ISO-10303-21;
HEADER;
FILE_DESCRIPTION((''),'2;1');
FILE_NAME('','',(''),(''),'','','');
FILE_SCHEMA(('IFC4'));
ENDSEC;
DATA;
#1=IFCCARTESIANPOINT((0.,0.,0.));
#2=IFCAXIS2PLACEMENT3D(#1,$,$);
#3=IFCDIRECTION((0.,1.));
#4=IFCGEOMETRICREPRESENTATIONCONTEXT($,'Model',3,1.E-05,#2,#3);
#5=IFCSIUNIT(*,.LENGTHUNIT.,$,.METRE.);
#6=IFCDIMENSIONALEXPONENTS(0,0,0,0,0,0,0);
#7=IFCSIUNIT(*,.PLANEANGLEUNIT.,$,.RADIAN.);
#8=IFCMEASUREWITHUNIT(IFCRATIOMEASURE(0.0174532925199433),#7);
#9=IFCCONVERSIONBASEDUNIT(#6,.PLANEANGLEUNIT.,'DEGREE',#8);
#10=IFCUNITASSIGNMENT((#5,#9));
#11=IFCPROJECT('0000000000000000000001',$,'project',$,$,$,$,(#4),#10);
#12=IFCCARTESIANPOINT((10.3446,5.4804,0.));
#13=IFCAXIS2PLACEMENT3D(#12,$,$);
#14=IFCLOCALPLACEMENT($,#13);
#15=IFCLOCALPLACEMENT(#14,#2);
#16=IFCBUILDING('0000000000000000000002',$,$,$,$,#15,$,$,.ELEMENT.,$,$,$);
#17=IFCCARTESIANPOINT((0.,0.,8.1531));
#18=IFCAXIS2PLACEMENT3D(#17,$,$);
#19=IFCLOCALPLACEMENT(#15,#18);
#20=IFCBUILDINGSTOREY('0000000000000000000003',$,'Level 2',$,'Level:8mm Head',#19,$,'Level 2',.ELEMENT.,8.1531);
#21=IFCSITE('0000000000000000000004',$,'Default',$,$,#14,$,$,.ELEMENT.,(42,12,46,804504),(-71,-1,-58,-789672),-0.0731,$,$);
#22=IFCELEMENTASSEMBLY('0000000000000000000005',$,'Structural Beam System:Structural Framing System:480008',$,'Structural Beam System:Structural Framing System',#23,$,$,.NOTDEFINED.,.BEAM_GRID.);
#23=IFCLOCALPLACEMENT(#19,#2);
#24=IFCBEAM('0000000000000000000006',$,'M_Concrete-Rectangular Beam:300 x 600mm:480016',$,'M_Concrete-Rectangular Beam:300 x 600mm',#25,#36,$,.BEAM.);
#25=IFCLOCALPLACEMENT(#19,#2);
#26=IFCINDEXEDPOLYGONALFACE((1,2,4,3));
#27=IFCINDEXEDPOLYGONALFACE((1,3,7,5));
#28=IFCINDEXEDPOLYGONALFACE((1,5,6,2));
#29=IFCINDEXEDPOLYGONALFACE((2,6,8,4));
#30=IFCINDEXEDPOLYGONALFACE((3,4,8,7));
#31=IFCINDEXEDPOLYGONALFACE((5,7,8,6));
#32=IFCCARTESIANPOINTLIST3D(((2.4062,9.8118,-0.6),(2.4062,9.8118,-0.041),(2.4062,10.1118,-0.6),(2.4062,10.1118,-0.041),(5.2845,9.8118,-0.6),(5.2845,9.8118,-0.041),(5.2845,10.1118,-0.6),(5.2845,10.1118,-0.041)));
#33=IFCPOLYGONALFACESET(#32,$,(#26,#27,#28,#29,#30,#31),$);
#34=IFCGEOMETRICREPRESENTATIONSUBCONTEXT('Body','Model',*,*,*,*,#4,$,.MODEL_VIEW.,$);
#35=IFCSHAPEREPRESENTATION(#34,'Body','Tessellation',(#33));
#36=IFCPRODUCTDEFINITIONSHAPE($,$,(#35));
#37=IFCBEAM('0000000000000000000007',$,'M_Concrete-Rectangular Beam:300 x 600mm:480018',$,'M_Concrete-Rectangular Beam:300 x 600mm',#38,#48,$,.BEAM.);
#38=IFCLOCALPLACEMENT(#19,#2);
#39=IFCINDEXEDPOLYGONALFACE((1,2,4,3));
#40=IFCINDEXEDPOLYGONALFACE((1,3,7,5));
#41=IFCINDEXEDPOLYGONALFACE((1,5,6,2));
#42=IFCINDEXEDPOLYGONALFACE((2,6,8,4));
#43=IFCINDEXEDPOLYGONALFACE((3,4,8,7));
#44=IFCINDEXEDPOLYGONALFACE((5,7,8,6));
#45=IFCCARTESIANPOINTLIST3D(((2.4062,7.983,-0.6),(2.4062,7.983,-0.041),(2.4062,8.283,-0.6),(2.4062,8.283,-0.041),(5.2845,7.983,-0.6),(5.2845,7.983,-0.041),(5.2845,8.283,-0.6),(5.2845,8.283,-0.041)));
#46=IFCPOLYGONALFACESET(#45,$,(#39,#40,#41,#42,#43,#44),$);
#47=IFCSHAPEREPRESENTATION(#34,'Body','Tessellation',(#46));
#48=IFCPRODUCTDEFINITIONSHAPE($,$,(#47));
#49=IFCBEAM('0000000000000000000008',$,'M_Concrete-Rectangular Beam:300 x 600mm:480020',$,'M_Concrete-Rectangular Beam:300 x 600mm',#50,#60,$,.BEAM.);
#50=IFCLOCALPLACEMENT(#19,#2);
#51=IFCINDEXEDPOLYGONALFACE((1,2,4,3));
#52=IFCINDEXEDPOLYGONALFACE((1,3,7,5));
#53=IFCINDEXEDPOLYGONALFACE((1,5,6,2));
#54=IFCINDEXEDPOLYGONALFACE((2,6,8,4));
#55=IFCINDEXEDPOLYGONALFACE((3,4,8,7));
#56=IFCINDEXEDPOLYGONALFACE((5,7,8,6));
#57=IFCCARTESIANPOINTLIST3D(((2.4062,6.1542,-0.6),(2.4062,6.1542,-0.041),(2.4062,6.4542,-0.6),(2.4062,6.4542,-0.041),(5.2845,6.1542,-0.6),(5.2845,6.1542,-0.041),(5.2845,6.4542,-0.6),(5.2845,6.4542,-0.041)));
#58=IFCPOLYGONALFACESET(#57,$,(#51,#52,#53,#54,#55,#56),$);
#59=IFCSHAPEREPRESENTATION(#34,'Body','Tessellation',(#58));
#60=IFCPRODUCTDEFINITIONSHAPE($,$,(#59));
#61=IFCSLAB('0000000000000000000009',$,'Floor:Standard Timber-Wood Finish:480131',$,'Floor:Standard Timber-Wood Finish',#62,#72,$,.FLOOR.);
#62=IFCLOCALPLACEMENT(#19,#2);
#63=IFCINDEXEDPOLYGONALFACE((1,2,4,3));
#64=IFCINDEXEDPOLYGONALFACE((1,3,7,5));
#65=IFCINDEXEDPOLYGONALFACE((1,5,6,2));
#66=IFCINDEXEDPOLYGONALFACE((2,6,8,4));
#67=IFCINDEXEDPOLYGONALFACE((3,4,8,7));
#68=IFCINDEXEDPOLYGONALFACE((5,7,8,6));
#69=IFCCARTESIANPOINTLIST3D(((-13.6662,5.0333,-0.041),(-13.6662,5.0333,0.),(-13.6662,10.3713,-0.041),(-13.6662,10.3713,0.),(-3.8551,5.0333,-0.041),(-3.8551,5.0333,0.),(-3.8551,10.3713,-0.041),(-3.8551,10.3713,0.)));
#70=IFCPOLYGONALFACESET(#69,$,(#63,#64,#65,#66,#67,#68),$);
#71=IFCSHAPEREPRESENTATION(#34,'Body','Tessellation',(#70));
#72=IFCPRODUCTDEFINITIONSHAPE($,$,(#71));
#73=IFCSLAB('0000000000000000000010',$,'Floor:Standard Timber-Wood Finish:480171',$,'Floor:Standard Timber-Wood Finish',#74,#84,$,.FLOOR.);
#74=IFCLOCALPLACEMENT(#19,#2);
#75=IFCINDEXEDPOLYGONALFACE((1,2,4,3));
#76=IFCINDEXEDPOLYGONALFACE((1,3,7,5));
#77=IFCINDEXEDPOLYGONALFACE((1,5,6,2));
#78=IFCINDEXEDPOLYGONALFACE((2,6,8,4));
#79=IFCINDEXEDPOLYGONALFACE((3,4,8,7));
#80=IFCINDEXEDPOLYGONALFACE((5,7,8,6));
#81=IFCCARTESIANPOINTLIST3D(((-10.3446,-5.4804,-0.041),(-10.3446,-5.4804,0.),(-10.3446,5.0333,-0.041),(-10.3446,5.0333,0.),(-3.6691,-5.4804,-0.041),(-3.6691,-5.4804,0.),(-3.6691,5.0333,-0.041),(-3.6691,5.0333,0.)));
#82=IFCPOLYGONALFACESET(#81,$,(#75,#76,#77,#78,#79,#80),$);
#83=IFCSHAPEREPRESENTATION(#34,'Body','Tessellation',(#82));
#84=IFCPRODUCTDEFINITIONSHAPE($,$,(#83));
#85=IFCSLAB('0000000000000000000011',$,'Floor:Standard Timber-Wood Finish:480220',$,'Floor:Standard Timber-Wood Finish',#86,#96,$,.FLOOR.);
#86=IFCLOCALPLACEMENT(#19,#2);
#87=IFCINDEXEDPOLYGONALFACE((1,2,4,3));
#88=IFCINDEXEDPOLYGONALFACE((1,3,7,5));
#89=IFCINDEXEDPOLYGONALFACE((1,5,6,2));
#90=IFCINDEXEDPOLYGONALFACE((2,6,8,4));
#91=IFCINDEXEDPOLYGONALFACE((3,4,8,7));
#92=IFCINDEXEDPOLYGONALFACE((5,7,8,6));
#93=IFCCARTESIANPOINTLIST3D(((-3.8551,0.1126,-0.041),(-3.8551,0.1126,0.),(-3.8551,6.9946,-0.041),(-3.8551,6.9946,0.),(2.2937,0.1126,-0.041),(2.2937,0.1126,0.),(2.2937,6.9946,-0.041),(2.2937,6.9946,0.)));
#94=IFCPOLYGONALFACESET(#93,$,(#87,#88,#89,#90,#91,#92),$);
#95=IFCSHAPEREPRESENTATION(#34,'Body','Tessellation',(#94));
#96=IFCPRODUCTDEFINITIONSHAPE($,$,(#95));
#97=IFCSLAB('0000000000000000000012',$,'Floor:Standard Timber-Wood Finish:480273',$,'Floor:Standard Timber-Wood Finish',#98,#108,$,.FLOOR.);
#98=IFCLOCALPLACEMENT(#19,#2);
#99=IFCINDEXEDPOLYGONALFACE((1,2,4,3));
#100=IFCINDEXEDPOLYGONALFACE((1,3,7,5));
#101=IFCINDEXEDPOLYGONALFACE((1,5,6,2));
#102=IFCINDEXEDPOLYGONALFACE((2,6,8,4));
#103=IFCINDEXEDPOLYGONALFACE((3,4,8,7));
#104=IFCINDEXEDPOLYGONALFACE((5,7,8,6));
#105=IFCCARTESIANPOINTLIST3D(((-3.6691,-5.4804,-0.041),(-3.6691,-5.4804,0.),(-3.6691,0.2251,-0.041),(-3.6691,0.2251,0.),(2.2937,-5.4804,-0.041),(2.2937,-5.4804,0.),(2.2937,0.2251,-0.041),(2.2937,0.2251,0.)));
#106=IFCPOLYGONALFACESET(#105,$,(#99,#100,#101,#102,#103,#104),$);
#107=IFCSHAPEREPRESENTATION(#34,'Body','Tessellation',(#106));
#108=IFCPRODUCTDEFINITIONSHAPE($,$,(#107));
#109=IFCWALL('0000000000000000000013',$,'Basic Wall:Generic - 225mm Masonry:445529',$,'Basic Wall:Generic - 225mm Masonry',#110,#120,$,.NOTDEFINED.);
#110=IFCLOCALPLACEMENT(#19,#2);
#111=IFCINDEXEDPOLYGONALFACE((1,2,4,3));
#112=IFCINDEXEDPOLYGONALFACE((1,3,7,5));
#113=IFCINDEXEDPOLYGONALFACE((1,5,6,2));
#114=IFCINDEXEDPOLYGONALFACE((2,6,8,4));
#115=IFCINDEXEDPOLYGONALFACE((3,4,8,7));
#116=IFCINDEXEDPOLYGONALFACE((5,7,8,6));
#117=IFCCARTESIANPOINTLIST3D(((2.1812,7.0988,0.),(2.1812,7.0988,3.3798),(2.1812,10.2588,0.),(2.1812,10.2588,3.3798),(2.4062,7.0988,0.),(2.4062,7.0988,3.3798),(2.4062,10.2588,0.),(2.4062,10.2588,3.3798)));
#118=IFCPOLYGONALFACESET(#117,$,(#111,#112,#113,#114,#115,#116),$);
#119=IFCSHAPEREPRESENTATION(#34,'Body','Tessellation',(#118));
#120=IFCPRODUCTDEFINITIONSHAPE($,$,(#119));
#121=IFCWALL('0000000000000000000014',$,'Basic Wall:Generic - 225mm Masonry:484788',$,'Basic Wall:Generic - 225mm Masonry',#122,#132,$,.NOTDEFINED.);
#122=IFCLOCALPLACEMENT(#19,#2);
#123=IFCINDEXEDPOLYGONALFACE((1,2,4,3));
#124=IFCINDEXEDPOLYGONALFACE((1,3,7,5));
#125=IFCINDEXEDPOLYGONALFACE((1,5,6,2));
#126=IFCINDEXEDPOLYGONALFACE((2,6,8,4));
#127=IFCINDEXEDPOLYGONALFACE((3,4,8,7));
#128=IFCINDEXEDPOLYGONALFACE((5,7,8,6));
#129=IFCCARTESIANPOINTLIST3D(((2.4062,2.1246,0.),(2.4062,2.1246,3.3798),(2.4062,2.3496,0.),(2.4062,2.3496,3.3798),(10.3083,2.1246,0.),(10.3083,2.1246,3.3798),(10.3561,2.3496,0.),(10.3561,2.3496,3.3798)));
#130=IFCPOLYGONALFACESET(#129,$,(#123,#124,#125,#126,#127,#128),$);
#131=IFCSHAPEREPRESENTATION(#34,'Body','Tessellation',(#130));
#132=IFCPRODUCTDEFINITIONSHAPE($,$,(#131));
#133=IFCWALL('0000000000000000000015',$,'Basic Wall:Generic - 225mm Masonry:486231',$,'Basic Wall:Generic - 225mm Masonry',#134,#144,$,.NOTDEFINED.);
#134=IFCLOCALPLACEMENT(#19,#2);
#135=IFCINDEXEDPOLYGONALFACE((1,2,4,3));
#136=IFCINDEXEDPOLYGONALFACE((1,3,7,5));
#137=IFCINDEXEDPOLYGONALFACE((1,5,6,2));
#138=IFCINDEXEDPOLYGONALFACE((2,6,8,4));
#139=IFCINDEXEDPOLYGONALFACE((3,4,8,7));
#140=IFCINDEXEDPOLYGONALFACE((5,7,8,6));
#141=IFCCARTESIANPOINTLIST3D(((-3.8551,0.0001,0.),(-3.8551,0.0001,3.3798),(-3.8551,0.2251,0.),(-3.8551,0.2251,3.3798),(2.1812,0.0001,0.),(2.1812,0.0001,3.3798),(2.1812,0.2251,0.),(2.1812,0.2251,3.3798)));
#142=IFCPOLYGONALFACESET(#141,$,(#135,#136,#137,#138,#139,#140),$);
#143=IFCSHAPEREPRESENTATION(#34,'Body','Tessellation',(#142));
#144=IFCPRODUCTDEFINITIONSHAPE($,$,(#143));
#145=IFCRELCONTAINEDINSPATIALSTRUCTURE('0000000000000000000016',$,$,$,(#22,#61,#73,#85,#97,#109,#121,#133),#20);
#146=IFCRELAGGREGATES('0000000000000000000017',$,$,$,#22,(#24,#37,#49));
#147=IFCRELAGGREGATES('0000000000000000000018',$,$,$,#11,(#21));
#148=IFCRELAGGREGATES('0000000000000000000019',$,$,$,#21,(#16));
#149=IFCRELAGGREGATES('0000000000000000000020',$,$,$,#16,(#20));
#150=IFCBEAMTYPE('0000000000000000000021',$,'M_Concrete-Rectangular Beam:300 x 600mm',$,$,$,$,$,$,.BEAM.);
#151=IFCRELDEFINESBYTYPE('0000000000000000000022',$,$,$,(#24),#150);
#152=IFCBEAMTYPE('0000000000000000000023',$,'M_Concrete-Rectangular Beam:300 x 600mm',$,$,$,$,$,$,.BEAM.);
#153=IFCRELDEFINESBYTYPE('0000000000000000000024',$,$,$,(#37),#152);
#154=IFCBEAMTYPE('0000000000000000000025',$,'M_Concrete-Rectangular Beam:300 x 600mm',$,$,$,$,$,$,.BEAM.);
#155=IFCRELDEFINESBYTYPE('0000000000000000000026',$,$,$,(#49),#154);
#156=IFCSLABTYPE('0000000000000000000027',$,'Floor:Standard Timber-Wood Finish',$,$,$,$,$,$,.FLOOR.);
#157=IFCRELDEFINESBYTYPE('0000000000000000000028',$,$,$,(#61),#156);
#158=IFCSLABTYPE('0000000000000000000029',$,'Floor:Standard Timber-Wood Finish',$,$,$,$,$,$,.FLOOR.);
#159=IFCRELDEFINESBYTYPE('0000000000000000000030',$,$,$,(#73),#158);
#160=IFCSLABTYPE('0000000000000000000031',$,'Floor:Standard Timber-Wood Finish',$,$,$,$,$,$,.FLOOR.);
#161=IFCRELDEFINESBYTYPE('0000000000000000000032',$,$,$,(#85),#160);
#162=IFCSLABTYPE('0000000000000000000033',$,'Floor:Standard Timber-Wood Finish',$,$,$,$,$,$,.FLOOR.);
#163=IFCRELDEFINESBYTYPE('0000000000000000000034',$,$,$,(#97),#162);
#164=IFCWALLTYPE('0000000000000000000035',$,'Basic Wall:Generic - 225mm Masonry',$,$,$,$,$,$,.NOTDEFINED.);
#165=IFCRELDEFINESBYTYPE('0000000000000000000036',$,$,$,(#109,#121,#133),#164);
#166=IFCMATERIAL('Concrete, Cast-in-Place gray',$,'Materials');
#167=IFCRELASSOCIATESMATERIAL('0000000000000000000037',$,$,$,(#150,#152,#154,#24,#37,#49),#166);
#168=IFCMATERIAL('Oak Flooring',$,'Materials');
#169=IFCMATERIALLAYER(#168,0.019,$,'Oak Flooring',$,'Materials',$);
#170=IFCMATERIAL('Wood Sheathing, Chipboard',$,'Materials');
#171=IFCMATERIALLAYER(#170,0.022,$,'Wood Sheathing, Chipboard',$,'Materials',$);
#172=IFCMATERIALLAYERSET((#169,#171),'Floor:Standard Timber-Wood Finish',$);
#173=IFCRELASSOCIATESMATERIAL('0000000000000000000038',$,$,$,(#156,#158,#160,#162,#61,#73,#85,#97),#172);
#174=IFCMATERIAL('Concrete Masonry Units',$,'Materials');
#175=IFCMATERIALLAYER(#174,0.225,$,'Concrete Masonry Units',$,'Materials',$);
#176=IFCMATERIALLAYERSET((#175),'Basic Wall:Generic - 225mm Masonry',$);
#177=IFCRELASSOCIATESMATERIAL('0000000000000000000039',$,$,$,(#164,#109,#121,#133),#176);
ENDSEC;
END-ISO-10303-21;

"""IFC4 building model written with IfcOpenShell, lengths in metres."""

from ifc_helpers import new_model, entity, si_unit, converted_unit, direction, frame, frame_2d, origin, origin_2d_with_axis, place, context, subcontext, project, spatial, polyline, rectangle, outline, extrude, clip, bounded_halfspace, source, transform, mapped, material, layer, layer_set, layer_usage, material_profile, profile_set, profile_usage, type_object, type_shapes, element, aggregate, save


model = new_model("IFC4")

# Units and contexts
model_context = context("Model", 3, precision=1e-05, world=origin(), true_north=direction((0.0, 1.0)))
body_context = subcontext(model_context, "Body", "Model", "MODEL_VIEW")
ifc_project = project(units=[si_unit("LENGTHUNIT", "METRE"), converted_unit("PLANEANGLEUNIT", "DEGREE", entity("IfcRatioMeasure", 0.0174532925199433), si_unit("PLANEANGLEUNIT", "RADIAN"), dimensions=[0, 0, 0, 0, 0, 0, 0])], contexts=[model_context])

# Site, building, storey
site_placement = place(None, frame((10.3446, 5.4804, 0.0)))
site = spatial("IfcSite", under=ifc_project, at=site_placement, Name="Default", CompositionType="ELEMENT", RefLatitude=(42, 12, 46, 804504), RefLongitude=(-71, -1, -58, -789672), RefElevation=-0.0731)
building_placement = place(site_placement, origin())
building = spatial("IfcBuilding", under=site, at=building_placement, CompositionType="ELEMENT")
storey_placement = place(building_placement, frame((0.0, 0.0, 8.1531)))
storey = spatial("IfcBuildingStorey", under=building, at=storey_placement, Name="Level 2", ObjectType="Level:8mm Head", LongName="Level 2", CompositionType="ELEMENT", Elevation=8.1531)

# Element assembly, beams
ifc_material_1 = material(Name="Concrete, Cast-in-Place gray", Category="Materials")
ifc_material_profile = material_profile(ifc_material_1, rectangle(XDim=0.559, YDim=0.3, at=frame_2d((0.0, 0.0), x_axis=(1.0, 0.0))), Name="300 x 600mm")
ifc_profile_set = profile_set([ifc_material_profile], Name="300 x 600mm")
assembly_1_placement = place(storey_placement, origin())
assembly_1 = element("IfcElementAssembly", 1, at=assembly_1_placement, inside=storey, Name="Structural Beam System:Structural Framing System:480008", ObjectType="Structural Beam System:Structural Framing System", AssemblyPlace="NOTDEFINED", PredefinedType="BEAM_GRID")
ifc_profile_usage_1 = profile_usage(ifc_profile_set, cardinal=8)
beam_type_1 = type_object("IfcBeamType", Name="M_Concrete-Rectangular Beam:300 x 600mm", PredefinedType="BEAM", material=ifc_profile_set)
shared_shape_1 = source(origin(), body_context, "Body", "SweptSolid", [
    extrude(rectangle(XDim=0.559, YDim=0.3, at=frame_2d((0.0, 0.0), x_axis=(1.0, 0.0))), frame((2.4062, 9.9618, 7.8326), z_axis=(1.0, 0.0, 0.0), x_axis=(0.0, 0.0, -1.0)), (0.0, 0.0, 1.0), 2.8784),
])
type_shapes(beam_type_1, [shared_shape_1])
beam_1_placement = place(assembly_1_placement, frame((0.0, 0.0, -8.1531)))
beam_1 = element("IfcBeam", 2, at=beam_1_placement, type_object=beam_type_1, material=ifc_profile_usage_1, Name="M_Concrete-Rectangular Beam:300 x 600mm:480016", ObjectType="M_Concrete-Rectangular Beam:300 x 600mm", PredefinedType="BEAM", context=body_context, shape_type="MappedRepresentation", body=[
    mapped(shared_shape_1, transform((0.0, 0.0, 0.0), scale=1.0)),
])
ifc_profile_usage_2 = profile_usage(ifc_profile_set, cardinal=8)
beam_type_2 = type_object("IfcBeamType", Name="M_Concrete-Rectangular Beam:300 x 600mm", PredefinedType="BEAM", material=ifc_profile_set)
shared_shape_2 = source(origin(), body_context, "Body", "SweptSolid", [
    extrude(rectangle(XDim=0.559, YDim=0.3, at=frame_2d((0.0, 0.0), x_axis=(1.0, 0.0))), frame((2.4062, 8.133, 7.8326), z_axis=(1.0, 0.0, 0.0), x_axis=(0.0, 0.0, -1.0)), (0.0, 0.0, 1.0), 2.8784),
])
type_shapes(beam_type_2, [shared_shape_2])
beam_2_placement = place(assembly_1_placement, frame((0.0, 0.0, -8.1531)))
beam_2 = element("IfcBeam", 3, at=beam_2_placement, type_object=beam_type_2, material=ifc_profile_usage_2, Name="M_Concrete-Rectangular Beam:300 x 600mm:480018", ObjectType="M_Concrete-Rectangular Beam:300 x 600mm", PredefinedType="BEAM", context=body_context, shape_type="MappedRepresentation", body=[
    mapped(shared_shape_2, transform((0.0, 0.0, 0.0), scale=1.0)),
])
ifc_profile_usage_3 = profile_usage(ifc_profile_set, cardinal=8)
beam_type_3 = type_object("IfcBeamType", Name="M_Concrete-Rectangular Beam:300 x 600mm", PredefinedType="BEAM", material=ifc_profile_set)
shared_shape_3 = source(origin(), body_context, "Body", "SweptSolid", [
    extrude(rectangle(XDim=0.559, YDim=0.3, at=frame_2d((0.0, 0.0), x_axis=(1.0, 0.0))), frame((2.4062, 6.3042, 7.8326), z_axis=(1.0, 0.0, 0.0), x_axis=(0.0, 0.0, -1.0)), (0.0, 0.0, 1.0), 2.8784),
])
type_shapes(beam_type_3, [shared_shape_3])
beam_3_placement = place(assembly_1_placement, frame((0.0, 0.0, -8.1531)))
beam_3 = element("IfcBeam", 4, at=beam_3_placement, type_object=beam_type_3, material=ifc_profile_usage_3, Name="M_Concrete-Rectangular Beam:300 x 600mm:480020", ObjectType="M_Concrete-Rectangular Beam:300 x 600mm", PredefinedType="BEAM", context=body_context, shape_type="MappedRepresentation", body=[
    mapped(shared_shape_3, transform((0.0, 0.0, 0.0), scale=1.0)),
])
aggregate(assembly_1, [beam_1, beam_2, beam_3])

# Slabs
ifc_material_2 = material(Name="Oak Flooring", Category="Materials")
ifc_layer_1 = layer(ifc_material_2, 0.019, Name="Oak Flooring", Category="Materials")
ifc_material_3 = material(Name="Wood Sheathing, Chipboard", Category="Materials")
ifc_layer_2 = layer(ifc_material_3, 0.022, Name="Wood Sheathing, Chipboard", Category="Materials")
ifc_layer_set_1 = layer_set([ifc_layer_1, ifc_layer_2], Name="Floor:Standard Timber-Wood Finish")
ifc_layer_usage_1 = layer_usage(ifc_layer_set_1, "AXIS3", "POSITIVE", 0.0)
slab_type_1 = type_object("IfcSlabType", Name="Floor:Standard Timber-Wood Finish", PredefinedType="FLOOR", material=ifc_layer_set_1)
slab_1_placement = place(storey_placement, origin())
element("IfcSlab", 5, at=slab_1_placement, inside=storey, type_object=slab_type_1, material=ifc_layer_usage_1, Name="Floor:Standard Timber-Wood Finish:480131", ObjectType="Floor:Standard Timber-Wood Finish", PredefinedType="FLOOR", context=body_context, shape_type="SweptSolid", body=[
    extrude(rectangle(XDim=5.338, YDim=9.8111, at=frame_2d((0.0, 0.0), x_axis=(1.0, 0.0))), frame((-8.7607, 7.7023, 0.0), z_axis=(0.0, 0.0, -1.0), x_axis=(0.0, 1.0, 0.0)), (0.0, 0.0, 1.0), 0.041),
])
ifc_layer_usage_2 = layer_usage(ifc_layer_set_1, "AXIS3", "POSITIVE", 0.0)
slab_type_2 = type_object("IfcSlabType", Name="Floor:Standard Timber-Wood Finish", PredefinedType="FLOOR", material=ifc_layer_set_1)
slab_2_placement = place(storey_placement, origin())
element("IfcSlab", 6, at=slab_2_placement, inside=storey, type_object=slab_type_2, material=ifc_layer_usage_2, Name="Floor:Standard Timber-Wood Finish:480171", ObjectType="Floor:Standard Timber-Wood Finish", PredefinedType="FLOOR", context=body_context, shape_type="SweptSolid", body=[
    extrude(rectangle(XDim=10.5138, YDim=6.6756, at=frame_2d((0.0, 0.0), x_axis=(1.0, 0.0))), frame((-7.0069, -0.2236, 0.0), z_axis=(0.0, 0.0, -1.0), x_axis=(0.0, 1.0, 0.0)), (0.0, 0.0, 1.0), 0.041),
])
ifc_layer_usage_3 = layer_usage(ifc_layer_set_1, "AXIS3", "POSITIVE", 0.0)
slab_type_3 = type_object("IfcSlabType", Name="Floor:Standard Timber-Wood Finish", PredefinedType="FLOOR", material=ifc_layer_set_1)
slab_3_placement = place(storey_placement, origin())
element("IfcSlab", 7, at=slab_3_placement, inside=storey, type_object=slab_type_3, material=ifc_layer_usage_3, Name="Floor:Standard Timber-Wood Finish:480220", ObjectType="Floor:Standard Timber-Wood Finish", PredefinedType="FLOOR", context=body_context, shape_type="SweptSolid", body=[
    extrude(rectangle(XDim=6.882, YDim=6.1488, at=frame_2d((0.0, 0.0), x_axis=(1.0, 0.0))), frame((-0.7807, 3.5536, 0.0), z_axis=(0.0, 0.0, -1.0), x_axis=(0.0, 1.0, 0.0)), (0.0, 0.0, 1.0), 0.041),
])
ifc_layer_usage_4 = layer_usage(ifc_layer_set_1, "AXIS3", "POSITIVE", 0.0)
slab_type_4 = type_object("IfcSlabType", Name="Floor:Standard Timber-Wood Finish", PredefinedType="FLOOR", material=ifc_layer_set_1)
slab_4_placement = place(storey_placement, origin())
element("IfcSlab", 8, at=slab_4_placement, inside=storey, type_object=slab_type_4, material=ifc_layer_usage_4, Name="Floor:Standard Timber-Wood Finish:480273", ObjectType="Floor:Standard Timber-Wood Finish", PredefinedType="FLOOR", context=body_context, shape_type="SweptSolid", body=[
    extrude(rectangle(XDim=5.7055, YDim=5.9627, at=origin_2d_with_axis()), frame((-0.6877, -2.6277, 0.0), z_axis=(0.0, 0.0, -1.0), x_axis=(0.0, 1.0, 0.0)), (0.0, 0.0, 1.0), 0.041),
])

# Walls
ifc_material_4 = material(Name="Concrete Masonry Units", Category="Materials")
ifc_layer_3 = layer(ifc_material_4, 0.225, Name="Concrete Masonry Units", Category="Materials")
ifc_layer_set_2 = layer_set([ifc_layer_3], Name="Basic Wall:Generic - 225mm Masonry")
wall_type = type_object("IfcWallType", Name="Basic Wall:Generic - 225mm Masonry", PredefinedType="NOTDEFINED", material=ifc_layer_set_2)
ifc_layer_usage_5 = layer_usage(ifc_layer_set_2, "AXIS2", "NEGATIVE", 0.1125)
wall_1_placement = place(storey_placement, frame((2.2937, 10.2588, 0.0), z_axis=(0.0, 0.0, 1.0), x_axis=(0.0, -1.0, 0.0)))
element("IfcWall", 9, at=wall_1_placement, inside=storey, type_object=wall_type, material=ifc_layer_usage_5, Name="Basic Wall:Generic - 225mm Masonry:445529", ObjectType="Basic Wall:Generic - 225mm Masonry", PredefinedType="NOTDEFINED", context=body_context, shape_type="Clipping", body=[
    clip(extrude(rectangle(XDim=3.16, YDim=0.225, at=frame_2d((1.58, 0.0), x_axis=(-1.0, 0.0))), origin(), (0.0, 0.0, 1.0), 3.3798), bounded_halfspace(frame((3.16, 0.0, 3.3798), z_axis=(0.0, 0.0, -1.0), x_axis=(0.978148, -0.207912, 0.0)), True, frame((3.16, 0.0, 3.3798)), polyline([(0.0, 0.0), (0.0, 0.1125), (-3.16, 0.1125), (-3.16, 0.0), (0.0, 0.0)]))),
])
ifc_layer_usage_6 = layer_usage(ifc_layer_set_2, "AXIS2", "NEGATIVE", 0.1125)
wall_2_placement = place(storey_placement, frame((2.4062, 2.2371, 0.0)))
element("IfcWall", 10, at=wall_2_placement, inside=storey, type_object=wall_type, material=ifc_layer_usage_6, Name="Basic Wall:Generic - 225mm Masonry:484788", ObjectType="Basic Wall:Generic - 225mm Masonry", PredefinedType="NOTDEFINED", context=body_context, shape_type="Clipping", body=[
    clip(clip(extrude(outline(polyline([(7.9022, -0.1125), (7.95, 0.1125), (0.0, 0.1125), (0.0, -0.1125), (7.9022, -0.1125)])), origin(), (0.0, 0.0, 1.0), 3.3798), bounded_halfspace(frame((0.0, -0.1125, 3.3798), z_axis=(0.0, 0.0, -1.0), x_axis=(-0.207912, -0.978148, 0.0)), True, frame((0.0, -0.1125, 3.3798)), polyline([(0.0, 0.0), (7.9022, 0.0), (7.9261, 0.1125), (0.0, 0.1125), (0.0, 0.0)]))), bounded_halfspace(frame((7.9261, 0.0, 3.3798), z_axis=(0.0, 0.0, -1.0), x_axis=(-0.207912, -0.978148, 0.0)), True, frame((7.9261, 0.0, 3.3798)), polyline([(0.0, 0.0), (0.0239, 0.1125), (-7.9261, 0.1125), (-7.9261, 0.0), (0.0, 0.0)]))),
])
ifc_layer_usage_7 = layer_usage(ifc_layer_set_2, "AXIS2", "NEGATIVE", 0.1125)
wall_3_placement = place(storey_placement, frame((2.1812, 0.1126, 0.0), z_axis=(0.0, 0.0, 1.0), x_axis=(-1.0, 0.0, 0.0)))
element("IfcWall", 11, at=wall_3_placement, inside=storey, type_object=wall_type, material=ifc_layer_usage_7, Name="Basic Wall:Generic - 225mm Masonry:486231", ObjectType="Basic Wall:Generic - 225mm Masonry", PredefinedType="NOTDEFINED", context=body_context, shape_type="Clipping", body=[
    clip(extrude(rectangle(XDim=6.0363, YDim=0.225, at=frame_2d((3.0181, 0.0), x_axis=(-1.0, 0.0))), origin(), (0.0, 0.0, 1.0), 3.3798), bounded_halfspace(frame((0.0, -0.1125, 3.3798), z_axis=(0.0, 0.0, -1.0), x_axis=(0.0, 1.0, 0.0)), True, frame((0.0, -0.1125, 3.3798)), polyline([(0.0, 0.0), (6.0363, 0.0), (6.0363, 0.1125), (0.0, 0.1125), (0.0, 0.0)]))),
])

save(model, "model.ifc")
